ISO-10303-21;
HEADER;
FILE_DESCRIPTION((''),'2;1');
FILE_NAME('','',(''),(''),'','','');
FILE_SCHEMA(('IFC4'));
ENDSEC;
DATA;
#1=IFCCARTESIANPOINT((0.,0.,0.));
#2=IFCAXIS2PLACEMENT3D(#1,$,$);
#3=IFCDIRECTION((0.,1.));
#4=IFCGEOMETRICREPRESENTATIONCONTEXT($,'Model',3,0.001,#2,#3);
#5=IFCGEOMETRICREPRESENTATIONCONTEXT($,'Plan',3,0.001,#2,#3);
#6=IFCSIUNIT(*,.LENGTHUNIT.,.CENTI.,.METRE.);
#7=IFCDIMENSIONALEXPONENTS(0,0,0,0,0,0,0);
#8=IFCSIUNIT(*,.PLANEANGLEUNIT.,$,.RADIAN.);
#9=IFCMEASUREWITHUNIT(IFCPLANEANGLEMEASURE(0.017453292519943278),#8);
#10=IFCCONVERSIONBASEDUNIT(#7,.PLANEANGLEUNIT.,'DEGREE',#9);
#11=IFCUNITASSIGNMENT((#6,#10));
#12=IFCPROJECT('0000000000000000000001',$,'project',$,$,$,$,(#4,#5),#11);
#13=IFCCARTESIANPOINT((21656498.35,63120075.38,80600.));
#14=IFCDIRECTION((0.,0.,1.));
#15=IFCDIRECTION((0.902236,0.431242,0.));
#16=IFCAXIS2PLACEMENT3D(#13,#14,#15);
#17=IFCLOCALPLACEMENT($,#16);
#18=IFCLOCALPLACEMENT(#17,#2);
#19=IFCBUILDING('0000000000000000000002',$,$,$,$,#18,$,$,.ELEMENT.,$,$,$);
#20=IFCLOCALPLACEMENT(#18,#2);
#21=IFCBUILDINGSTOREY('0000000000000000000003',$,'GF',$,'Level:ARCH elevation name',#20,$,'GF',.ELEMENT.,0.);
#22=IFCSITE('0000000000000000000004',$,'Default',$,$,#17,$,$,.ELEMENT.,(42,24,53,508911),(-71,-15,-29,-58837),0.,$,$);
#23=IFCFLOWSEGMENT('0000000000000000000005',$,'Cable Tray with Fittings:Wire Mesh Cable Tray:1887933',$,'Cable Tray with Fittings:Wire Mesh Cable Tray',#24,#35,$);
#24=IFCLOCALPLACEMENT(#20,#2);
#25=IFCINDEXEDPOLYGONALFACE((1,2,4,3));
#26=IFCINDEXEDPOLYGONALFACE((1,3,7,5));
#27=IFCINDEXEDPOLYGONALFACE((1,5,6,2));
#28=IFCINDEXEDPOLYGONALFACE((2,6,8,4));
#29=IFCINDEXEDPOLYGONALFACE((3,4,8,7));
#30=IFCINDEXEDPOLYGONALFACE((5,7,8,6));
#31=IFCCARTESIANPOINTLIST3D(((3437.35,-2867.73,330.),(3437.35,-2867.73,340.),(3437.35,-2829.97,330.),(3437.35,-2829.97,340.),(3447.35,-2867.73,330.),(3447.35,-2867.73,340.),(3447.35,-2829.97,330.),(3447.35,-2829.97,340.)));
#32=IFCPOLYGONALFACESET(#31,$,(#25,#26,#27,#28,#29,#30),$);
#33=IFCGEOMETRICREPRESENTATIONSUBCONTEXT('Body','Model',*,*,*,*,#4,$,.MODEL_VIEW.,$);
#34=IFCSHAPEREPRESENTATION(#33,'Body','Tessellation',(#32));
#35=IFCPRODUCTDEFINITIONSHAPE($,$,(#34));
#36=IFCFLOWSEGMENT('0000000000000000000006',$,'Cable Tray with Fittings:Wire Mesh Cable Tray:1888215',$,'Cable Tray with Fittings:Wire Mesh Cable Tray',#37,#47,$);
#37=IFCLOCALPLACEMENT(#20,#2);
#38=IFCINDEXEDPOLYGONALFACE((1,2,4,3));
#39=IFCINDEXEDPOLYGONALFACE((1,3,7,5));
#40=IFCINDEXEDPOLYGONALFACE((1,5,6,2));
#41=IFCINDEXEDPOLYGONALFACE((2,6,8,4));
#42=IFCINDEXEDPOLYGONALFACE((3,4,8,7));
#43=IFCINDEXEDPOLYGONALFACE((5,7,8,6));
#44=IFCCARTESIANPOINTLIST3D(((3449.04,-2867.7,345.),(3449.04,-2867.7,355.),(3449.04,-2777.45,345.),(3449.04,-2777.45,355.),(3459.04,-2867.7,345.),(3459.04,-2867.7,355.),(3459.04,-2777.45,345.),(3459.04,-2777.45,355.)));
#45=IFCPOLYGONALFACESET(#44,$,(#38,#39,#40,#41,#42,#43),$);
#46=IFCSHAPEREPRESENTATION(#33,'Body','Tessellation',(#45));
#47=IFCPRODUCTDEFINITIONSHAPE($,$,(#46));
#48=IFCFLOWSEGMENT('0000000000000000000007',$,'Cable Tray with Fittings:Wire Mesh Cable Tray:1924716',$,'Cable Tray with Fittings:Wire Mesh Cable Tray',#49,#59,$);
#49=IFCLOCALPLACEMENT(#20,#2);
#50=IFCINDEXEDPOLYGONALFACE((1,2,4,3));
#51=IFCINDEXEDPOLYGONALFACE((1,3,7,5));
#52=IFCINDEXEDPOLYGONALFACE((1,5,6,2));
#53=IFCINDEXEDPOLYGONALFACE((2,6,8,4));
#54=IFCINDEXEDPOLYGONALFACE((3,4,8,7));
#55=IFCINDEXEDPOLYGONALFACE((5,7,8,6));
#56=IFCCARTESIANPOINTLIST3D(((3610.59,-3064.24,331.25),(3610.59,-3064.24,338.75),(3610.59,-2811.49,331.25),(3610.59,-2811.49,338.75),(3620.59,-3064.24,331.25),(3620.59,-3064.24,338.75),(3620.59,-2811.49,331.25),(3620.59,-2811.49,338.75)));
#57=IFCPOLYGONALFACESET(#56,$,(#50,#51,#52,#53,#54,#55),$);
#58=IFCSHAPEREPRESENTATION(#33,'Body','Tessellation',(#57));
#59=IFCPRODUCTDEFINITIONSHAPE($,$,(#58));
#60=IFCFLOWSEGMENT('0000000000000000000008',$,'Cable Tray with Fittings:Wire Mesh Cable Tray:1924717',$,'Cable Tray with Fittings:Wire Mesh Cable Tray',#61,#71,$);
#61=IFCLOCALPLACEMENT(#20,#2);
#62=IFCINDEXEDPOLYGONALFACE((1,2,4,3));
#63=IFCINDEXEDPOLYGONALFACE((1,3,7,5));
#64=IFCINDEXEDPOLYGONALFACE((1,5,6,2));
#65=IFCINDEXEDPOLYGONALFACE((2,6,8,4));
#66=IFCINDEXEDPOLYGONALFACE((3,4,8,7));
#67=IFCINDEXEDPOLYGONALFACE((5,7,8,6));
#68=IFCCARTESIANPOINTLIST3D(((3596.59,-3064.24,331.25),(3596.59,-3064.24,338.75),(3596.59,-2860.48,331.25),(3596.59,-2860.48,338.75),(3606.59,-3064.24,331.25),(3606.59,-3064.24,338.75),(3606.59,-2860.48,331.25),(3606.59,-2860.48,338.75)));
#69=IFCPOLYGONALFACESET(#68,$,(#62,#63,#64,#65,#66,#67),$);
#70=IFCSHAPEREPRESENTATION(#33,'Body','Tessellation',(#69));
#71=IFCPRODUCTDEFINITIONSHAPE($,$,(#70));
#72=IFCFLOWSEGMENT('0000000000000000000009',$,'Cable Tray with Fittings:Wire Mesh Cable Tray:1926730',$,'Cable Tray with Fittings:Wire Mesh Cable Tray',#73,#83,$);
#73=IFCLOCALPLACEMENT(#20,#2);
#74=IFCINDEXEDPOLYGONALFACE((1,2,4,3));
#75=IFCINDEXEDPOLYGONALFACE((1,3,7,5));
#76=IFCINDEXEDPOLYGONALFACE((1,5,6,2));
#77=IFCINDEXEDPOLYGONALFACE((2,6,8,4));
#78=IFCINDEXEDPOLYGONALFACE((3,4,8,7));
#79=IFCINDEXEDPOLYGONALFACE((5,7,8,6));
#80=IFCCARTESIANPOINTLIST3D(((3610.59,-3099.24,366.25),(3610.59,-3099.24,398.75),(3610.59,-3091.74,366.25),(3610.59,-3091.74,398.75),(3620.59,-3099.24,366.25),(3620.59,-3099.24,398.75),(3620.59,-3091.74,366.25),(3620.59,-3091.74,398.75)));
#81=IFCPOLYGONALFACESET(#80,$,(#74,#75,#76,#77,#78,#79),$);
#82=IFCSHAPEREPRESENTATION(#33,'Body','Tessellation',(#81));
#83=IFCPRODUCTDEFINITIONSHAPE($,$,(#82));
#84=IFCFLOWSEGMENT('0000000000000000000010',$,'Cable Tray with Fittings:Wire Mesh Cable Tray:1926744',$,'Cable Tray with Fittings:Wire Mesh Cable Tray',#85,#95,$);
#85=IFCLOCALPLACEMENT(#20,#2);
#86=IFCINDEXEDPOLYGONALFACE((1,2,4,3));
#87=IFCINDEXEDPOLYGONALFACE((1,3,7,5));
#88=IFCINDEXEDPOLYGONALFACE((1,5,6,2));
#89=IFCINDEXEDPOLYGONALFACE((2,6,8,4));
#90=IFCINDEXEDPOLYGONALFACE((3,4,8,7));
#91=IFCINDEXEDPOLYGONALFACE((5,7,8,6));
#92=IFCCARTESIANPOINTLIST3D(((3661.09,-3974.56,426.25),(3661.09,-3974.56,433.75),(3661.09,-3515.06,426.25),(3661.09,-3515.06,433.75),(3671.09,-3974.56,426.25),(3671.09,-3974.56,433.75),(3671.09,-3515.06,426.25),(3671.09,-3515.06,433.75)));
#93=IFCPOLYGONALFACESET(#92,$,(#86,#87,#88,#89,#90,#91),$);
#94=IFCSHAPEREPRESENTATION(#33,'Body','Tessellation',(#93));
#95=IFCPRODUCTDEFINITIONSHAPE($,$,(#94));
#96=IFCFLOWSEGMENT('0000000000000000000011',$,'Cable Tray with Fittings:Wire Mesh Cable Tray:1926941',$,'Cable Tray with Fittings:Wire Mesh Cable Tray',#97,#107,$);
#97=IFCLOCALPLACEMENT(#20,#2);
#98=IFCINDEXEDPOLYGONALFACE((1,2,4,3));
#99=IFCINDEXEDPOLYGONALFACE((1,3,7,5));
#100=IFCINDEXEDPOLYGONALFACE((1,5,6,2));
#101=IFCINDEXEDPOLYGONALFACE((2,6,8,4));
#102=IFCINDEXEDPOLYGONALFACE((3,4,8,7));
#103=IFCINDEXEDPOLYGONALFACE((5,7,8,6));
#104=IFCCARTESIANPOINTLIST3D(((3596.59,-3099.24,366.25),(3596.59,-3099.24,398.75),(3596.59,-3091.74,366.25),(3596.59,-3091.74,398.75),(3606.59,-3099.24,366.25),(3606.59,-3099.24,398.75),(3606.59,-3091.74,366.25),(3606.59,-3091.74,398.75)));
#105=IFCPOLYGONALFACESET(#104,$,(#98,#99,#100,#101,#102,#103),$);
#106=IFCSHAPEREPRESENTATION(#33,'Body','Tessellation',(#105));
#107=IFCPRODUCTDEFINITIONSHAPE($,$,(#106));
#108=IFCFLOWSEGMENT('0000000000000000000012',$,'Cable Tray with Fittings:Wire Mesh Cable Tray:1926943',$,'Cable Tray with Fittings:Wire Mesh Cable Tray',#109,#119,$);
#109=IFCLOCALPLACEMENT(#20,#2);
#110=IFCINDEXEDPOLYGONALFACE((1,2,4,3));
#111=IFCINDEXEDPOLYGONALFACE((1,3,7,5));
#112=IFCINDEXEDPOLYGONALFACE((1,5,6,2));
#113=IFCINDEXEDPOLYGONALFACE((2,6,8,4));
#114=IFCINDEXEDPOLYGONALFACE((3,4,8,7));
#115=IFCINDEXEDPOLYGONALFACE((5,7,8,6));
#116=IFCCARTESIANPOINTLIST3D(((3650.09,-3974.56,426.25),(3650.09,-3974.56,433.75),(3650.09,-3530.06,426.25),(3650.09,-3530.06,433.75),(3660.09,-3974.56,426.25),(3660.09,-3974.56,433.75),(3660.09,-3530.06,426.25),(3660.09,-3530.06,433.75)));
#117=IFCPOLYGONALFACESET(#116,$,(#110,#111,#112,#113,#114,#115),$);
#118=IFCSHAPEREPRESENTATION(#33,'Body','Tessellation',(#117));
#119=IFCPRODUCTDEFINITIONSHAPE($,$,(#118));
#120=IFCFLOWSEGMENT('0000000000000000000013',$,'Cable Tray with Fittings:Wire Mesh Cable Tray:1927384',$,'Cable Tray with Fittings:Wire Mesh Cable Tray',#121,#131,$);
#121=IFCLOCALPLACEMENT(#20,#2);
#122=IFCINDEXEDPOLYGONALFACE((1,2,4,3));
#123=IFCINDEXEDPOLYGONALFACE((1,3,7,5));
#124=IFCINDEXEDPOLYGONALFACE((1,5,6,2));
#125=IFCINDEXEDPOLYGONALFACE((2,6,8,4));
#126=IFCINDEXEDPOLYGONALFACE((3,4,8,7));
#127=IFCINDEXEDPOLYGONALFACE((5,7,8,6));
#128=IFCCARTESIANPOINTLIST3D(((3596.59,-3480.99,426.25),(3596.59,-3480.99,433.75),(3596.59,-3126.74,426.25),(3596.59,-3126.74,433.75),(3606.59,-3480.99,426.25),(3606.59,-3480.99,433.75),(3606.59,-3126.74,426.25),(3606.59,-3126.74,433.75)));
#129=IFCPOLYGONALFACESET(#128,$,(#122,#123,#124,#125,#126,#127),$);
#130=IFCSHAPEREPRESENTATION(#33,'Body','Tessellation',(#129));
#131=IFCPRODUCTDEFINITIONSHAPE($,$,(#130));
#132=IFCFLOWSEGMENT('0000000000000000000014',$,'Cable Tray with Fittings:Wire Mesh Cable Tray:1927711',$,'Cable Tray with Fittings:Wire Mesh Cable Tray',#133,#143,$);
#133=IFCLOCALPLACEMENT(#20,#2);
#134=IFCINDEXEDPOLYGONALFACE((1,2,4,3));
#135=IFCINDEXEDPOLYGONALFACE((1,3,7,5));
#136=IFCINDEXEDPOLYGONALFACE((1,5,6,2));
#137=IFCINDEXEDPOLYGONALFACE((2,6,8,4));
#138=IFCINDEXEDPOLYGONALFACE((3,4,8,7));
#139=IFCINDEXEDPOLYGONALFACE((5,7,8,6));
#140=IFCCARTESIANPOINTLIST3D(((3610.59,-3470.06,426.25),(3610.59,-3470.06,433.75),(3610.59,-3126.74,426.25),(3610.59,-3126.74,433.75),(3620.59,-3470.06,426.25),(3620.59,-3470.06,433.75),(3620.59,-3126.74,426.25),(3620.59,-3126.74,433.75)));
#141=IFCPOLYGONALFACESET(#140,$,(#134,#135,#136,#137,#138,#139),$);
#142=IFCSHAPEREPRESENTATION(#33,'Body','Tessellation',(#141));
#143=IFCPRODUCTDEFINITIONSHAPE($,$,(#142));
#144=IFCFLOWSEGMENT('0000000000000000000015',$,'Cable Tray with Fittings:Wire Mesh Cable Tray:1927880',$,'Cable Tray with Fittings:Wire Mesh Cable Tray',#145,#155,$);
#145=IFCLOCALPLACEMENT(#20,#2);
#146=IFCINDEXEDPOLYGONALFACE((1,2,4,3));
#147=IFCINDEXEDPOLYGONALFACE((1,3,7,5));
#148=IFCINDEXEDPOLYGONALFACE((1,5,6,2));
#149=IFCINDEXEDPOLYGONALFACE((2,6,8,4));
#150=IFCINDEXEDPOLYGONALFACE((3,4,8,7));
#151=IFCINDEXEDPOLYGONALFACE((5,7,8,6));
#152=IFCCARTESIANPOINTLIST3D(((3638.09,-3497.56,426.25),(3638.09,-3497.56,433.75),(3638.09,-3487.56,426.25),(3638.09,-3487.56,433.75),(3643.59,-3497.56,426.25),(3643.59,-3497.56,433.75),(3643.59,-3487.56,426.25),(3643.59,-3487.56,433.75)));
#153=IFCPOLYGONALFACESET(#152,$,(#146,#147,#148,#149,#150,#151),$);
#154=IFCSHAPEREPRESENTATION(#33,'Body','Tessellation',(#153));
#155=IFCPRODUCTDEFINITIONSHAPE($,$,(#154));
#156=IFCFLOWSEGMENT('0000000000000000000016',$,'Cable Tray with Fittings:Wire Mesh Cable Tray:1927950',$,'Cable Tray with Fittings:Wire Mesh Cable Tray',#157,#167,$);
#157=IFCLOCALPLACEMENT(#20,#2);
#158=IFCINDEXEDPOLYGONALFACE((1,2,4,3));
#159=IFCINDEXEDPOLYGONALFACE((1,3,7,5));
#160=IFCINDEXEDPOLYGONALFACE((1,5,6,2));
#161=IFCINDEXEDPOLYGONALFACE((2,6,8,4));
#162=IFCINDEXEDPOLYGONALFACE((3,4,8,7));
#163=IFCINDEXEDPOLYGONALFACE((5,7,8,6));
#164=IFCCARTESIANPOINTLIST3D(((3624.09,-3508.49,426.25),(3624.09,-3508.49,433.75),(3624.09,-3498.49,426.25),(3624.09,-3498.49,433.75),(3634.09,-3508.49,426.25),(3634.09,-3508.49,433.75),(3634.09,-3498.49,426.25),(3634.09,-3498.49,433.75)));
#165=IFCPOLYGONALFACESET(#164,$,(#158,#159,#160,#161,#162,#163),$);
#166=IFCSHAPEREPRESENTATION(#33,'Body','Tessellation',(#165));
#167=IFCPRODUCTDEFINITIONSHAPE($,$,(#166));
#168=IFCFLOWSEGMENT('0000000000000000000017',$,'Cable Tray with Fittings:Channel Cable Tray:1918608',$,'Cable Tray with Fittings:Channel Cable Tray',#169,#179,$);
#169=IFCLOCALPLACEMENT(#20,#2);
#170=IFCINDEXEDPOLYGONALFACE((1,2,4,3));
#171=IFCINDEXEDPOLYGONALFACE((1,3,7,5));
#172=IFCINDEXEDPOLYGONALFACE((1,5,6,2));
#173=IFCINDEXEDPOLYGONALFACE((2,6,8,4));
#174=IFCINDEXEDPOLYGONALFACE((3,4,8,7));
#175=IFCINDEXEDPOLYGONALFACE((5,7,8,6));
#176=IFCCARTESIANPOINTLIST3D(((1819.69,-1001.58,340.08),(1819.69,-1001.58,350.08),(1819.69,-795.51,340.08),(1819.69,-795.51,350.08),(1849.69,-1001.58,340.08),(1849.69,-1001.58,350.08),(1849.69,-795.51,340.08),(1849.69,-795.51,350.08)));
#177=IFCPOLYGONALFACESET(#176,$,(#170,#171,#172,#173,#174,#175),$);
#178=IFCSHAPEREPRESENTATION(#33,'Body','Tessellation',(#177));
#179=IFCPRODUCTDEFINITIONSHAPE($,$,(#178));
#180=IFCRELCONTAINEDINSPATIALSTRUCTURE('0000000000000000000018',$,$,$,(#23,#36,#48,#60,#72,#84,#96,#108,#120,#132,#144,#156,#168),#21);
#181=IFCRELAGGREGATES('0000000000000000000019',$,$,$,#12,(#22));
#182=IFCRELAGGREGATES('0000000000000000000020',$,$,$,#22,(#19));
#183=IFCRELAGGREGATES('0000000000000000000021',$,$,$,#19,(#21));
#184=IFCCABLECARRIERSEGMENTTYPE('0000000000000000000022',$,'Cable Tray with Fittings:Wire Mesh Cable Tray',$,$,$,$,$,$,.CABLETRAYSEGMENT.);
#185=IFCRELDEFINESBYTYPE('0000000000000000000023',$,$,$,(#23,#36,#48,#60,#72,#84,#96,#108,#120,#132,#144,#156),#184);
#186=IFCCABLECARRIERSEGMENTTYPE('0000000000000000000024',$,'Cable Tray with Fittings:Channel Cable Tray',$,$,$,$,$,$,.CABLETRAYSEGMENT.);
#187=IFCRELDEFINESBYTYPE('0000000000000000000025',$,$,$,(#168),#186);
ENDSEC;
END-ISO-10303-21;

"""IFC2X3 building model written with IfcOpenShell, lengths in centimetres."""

from ifc_helpers import new_model, entity, si_unit, converted_unit, direction, frame, frame_2d, origin, origin_2d_with_axis, place, context, subcontext, project, spatial, rectangle, extrude, type_object, element, save


model = new_model("IFC2X3")

# Units and contexts
model_context = context("Model", 3, precision=0.001, world=origin(), true_north=direction((0.0, 1.0)))
plan_context = context("Plan", 3, precision=0.001, world=origin(), true_north=direction((0.0, 1.0)))
body_context = subcontext(model_context, "Body", "Model", "MODEL_VIEW")
ifc_project = project(units=[si_unit("LENGTHUNIT", "METRE", prefix="CENTI"), converted_unit("PLANEANGLEUNIT", "DEGREE", entity("IfcPlaneAngleMeasure", 0.017453292519943278), si_unit("PLANEANGLEUNIT", "RADIAN"), dimensions=[0, 0, 0, 0, 0, 0, 0])], contexts=[model_context, plan_context])

# Site, building, storey
site_placement = place(None, frame((21656498.35, 63120075.38, 80600.0), z_axis=(0.0, 0.0, 1.0), x_axis=(0.902236, 0.431242, 0.0)))
site = spatial("IfcSite", under=ifc_project, at=site_placement, Name="Default", CompositionType="ELEMENT", RefLatitude=(42, 24, 53, 508911), RefLongitude=(-71, -15, -29, -58837), RefElevation=0.0)
building_placement = place(site_placement, origin())
building = spatial("IfcBuilding", under=site, at=building_placement, CompositionType="ELEMENT")
storey_placement = place(building_placement, origin())
storey = spatial("IfcBuildingStorey", under=building, at=storey_placement, Name="GF", ObjectType="Level:ARCH elevation name", LongName="GF", CompositionType="ELEMENT", Elevation=0.0)

# Flow segments
cable_carrier_segment_type_1 = type_object("IfcCableCarrierSegmentType", Name="Cable Tray with Fittings:Wire Mesh Cable Tray", PredefinedType="CABLETRAYSEGMENT")
flow_segment_1_placement = place(storey_placement, origin())
element("IfcFlowSegment", 1, at=flow_segment_1_placement, inside=storey, type_object=cable_carrier_segment_type_1, Name="Cable Tray with Fittings:Wire Mesh Cable Tray:1887933", ObjectType="Cable Tray with Fittings:Wire Mesh Cable Tray", context=body_context, shape_type="SweptSolid", body=[
    extrude(rectangle(XDim=37.76, YDim=10.0, at=frame_2d((0.0, 0.0), x_axis=(1.0, 0.0))), frame((3442.35, -2848.85, 330.0), z_axis=(0.0, 0.0, 1.0), x_axis=(0.0, 1.0, 0.0)), (0.0, 0.0, 1.0), 10.0),
])
flow_segment_2_placement = place(storey_placement, origin())
element("IfcFlowSegment", 2, at=flow_segment_2_placement, inside=storey, type_object=cable_carrier_segment_type_1, Name="Cable Tray with Fittings:Wire Mesh Cable Tray:1888215", ObjectType="Cable Tray with Fittings:Wire Mesh Cable Tray", context=body_context, shape_type="SweptSolid", body=[
    extrude(rectangle(XDim=90.25, YDim=10.0, at=frame_2d((0.0, 0.0), x_axis=(1.0, 0.0))), frame((3454.04, -2822.57, 345.0), z_axis=(0.0, 0.0, 1.0), x_axis=(0.0, 1.0, 0.0)), (0.0, 0.0, 1.0), 10.0),
])
flow_segment_3_placement = place(storey_placement, origin())
element("IfcFlowSegment", 3, at=flow_segment_3_placement, inside=storey, type_object=cable_carrier_segment_type_1, Name="Cable Tray with Fittings:Wire Mesh Cable Tray:1924716", ObjectType="Cable Tray with Fittings:Wire Mesh Cable Tray", context=body_context, shape_type="SweptSolid", body=[
    extrude(rectangle(XDim=252.75, YDim=10.0, at=frame_2d((0.0, 0.0), x_axis=(1.0, 0.0))), frame((3615.59, -2937.87, 331.25), z_axis=(0.0, 0.0, 1.0), x_axis=(0.0, 1.0, 0.0)), (0.0, 0.0, 1.0), 7.5),
])
flow_segment_4_placement = place(storey_placement, origin())
element("IfcFlowSegment", 4, at=flow_segment_4_placement, inside=storey, type_object=cable_carrier_segment_type_1, Name="Cable Tray with Fittings:Wire Mesh Cable Tray:1924717", ObjectType="Cable Tray with Fittings:Wire Mesh Cable Tray", context=body_context, shape_type="SweptSolid", body=[
    extrude(rectangle(XDim=203.76, YDim=10.0, at=origin_2d_with_axis()), frame((3601.59, -2962.36, 331.25), z_axis=(0.0, 0.0, 1.0), x_axis=(0.0, 1.0, 0.0)), (0.0, 0.0, 1.0), 7.5),
])
flow_segment_5_placement = place(storey_placement, origin())
element("IfcFlowSegment", 5, at=flow_segment_5_placement, inside=storey, type_object=cable_carrier_segment_type_1, Name="Cable Tray with Fittings:Wire Mesh Cable Tray:1926730", ObjectType="Cable Tray with Fittings:Wire Mesh Cable Tray", context=body_context, shape_type="SweptSolid", body=[
    extrude(rectangle(XDim=10.0, YDim=7.5, at=origin_2d_with_axis()), frame((3615.59, -3095.49, 366.25)), (0.0, 0.0, 1.0), 32.5),
])
flow_segment_6_placement = place(storey_placement, origin())
element("IfcFlowSegment", 6, at=flow_segment_6_placement, inside=storey, type_object=cable_carrier_segment_type_1, Name="Cable Tray with Fittings:Wire Mesh Cable Tray:1926744", ObjectType="Cable Tray with Fittings:Wire Mesh Cable Tray", context=body_context, shape_type="SweptSolid", body=[
    extrude(rectangle(XDim=459.5, YDim=10.0, at=frame_2d((0.0, 0.0), x_axis=(1.0, 0.0))), frame((3666.09, -3744.81, 426.25), z_axis=(0.0, 0.0, 1.0), x_axis=(0.0, -1.0, 0.0)), (0.0, 0.0, 1.0), 7.5),
])
flow_segment_7_placement = place(storey_placement, origin())
element("IfcFlowSegment", 7, at=flow_segment_7_placement, inside=storey, type_object=cable_carrier_segment_type_1, Name="Cable Tray with Fittings:Wire Mesh Cable Tray:1926941", ObjectType="Cable Tray with Fittings:Wire Mesh Cable Tray", context=body_context, shape_type="SweptSolid", body=[
    extrude(rectangle(XDim=10.0, YDim=7.5, at=origin_2d_with_axis()), frame((3601.59, -3095.49, 366.25)), (0.0, 0.0, 1.0), 32.5),
])
flow_segment_8_placement = place(storey_placement, origin())
element("IfcFlowSegment", 8, at=flow_segment_8_placement, inside=storey, type_object=cable_carrier_segment_type_1, Name="Cable Tray with Fittings:Wire Mesh Cable Tray:1926943", ObjectType="Cable Tray with Fittings:Wire Mesh Cable Tray", context=body_context, shape_type="SweptSolid", body=[
    extrude(rectangle(XDim=444.5, YDim=10.0, at=frame_2d((0.0, 0.0), x_axis=(1.0, 0.0))), frame((3655.09, -3752.31, 426.25), z_axis=(0.0, 0.0, 1.0), x_axis=(0.0, -1.0, 0.0)), (0.0, 0.0, 1.0), 7.5),
])
flow_segment_9_placement = place(storey_placement, origin())
element("IfcFlowSegment", 9, at=flow_segment_9_placement, inside=storey, type_object=cable_carrier_segment_type_1, Name="Cable Tray with Fittings:Wire Mesh Cable Tray:1927384", ObjectType="Cable Tray with Fittings:Wire Mesh Cable Tray", context=body_context, shape_type="SweptSolid", body=[
    extrude(rectangle(XDim=354.25, YDim=10.0, at=frame_2d((0.0, 0.0), x_axis=(1.0, 0.0))), frame((3601.59, -3303.87, 426.25), z_axis=(0.0, 0.0, 1.0), x_axis=(0.0, -1.0, 0.0)), (0.0, 0.0, 1.0), 7.5),
])
flow_segment_10_placement = place(storey_placement, origin())
element("IfcFlowSegment", 10, at=flow_segment_10_placement, inside=storey, type_object=cable_carrier_segment_type_1, Name="Cable Tray with Fittings:Wire Mesh Cable Tray:1927711", ObjectType="Cable Tray with Fittings:Wire Mesh Cable Tray", context=body_context, shape_type="SweptSolid", body=[
    extrude(rectangle(XDim=343.32, YDim=10.0, at=frame_2d((0.0, 0.0), x_axis=(1.0, 0.0))), frame((3615.59, -3298.4, 426.25), z_axis=(0.0, 0.0, 1.0), x_axis=(0.0, -1.0, 0.0)), (0.0, 0.0, 1.0), 7.5),
])
flow_segment_11_placement = place(storey_placement, origin())
element("IfcFlowSegment", 11, at=flow_segment_11_placement, inside=storey, type_object=cable_carrier_segment_type_1, Name="Cable Tray with Fittings:Wire Mesh Cable Tray:1927880", ObjectType="Cable Tray with Fittings:Wire Mesh Cable Tray", context=body_context, shape_type="SweptSolid", body=[
    extrude(rectangle(XDim=5.5, YDim=10.0, at=frame_2d((0.0, 0.0), x_axis=(1.0, 0.0))), frame((3640.84, -3492.56, 426.25)), (0.0, 0.0, 1.0), 7.5),
])
flow_segment_12_placement = place(storey_placement, origin())
element("IfcFlowSegment", 12, at=flow_segment_12_placement, inside=storey, type_object=cable_carrier_segment_type_1, Name="Cable Tray with Fittings:Wire Mesh Cable Tray:1927950", ObjectType="Cable Tray with Fittings:Wire Mesh Cable Tray", context=body_context, shape_type="SweptSolid", body=[
    extrude(rectangle(XDim=10.0, YDim=10.0, at=origin_2d_with_axis()), frame((3629.09, -3503.49, 426.25)), (0.0, 0.0, 1.0), 7.5),
])
cable_carrier_segment_type_2 = type_object("IfcCableCarrierSegmentType", Name="Cable Tray with Fittings:Channel Cable Tray", PredefinedType="CABLETRAYSEGMENT")
flow_segment_13_placement = place(storey_placement, origin())
element("IfcFlowSegment", 13, at=flow_segment_13_placement, inside=storey, type_object=cable_carrier_segment_type_2, Name="Cable Tray with Fittings:Channel Cable Tray:1918608", ObjectType="Cable Tray with Fittings:Channel Cable Tray", context=body_context, shape_type="SweptSolid", body=[
    extrude(rectangle(XDim=206.06, YDim=30.0, at=frame_2d((0.0, 0.0), x_axis=(1.0, 0.0))), frame((1834.69, -898.55, 340.08), z_axis=(0.0, 0.0, 1.0), x_axis=(0.0, -1.0, 0.0)), (0.0, 0.0, 1.0), 10.0),
])

save(model, "model.ifc")
